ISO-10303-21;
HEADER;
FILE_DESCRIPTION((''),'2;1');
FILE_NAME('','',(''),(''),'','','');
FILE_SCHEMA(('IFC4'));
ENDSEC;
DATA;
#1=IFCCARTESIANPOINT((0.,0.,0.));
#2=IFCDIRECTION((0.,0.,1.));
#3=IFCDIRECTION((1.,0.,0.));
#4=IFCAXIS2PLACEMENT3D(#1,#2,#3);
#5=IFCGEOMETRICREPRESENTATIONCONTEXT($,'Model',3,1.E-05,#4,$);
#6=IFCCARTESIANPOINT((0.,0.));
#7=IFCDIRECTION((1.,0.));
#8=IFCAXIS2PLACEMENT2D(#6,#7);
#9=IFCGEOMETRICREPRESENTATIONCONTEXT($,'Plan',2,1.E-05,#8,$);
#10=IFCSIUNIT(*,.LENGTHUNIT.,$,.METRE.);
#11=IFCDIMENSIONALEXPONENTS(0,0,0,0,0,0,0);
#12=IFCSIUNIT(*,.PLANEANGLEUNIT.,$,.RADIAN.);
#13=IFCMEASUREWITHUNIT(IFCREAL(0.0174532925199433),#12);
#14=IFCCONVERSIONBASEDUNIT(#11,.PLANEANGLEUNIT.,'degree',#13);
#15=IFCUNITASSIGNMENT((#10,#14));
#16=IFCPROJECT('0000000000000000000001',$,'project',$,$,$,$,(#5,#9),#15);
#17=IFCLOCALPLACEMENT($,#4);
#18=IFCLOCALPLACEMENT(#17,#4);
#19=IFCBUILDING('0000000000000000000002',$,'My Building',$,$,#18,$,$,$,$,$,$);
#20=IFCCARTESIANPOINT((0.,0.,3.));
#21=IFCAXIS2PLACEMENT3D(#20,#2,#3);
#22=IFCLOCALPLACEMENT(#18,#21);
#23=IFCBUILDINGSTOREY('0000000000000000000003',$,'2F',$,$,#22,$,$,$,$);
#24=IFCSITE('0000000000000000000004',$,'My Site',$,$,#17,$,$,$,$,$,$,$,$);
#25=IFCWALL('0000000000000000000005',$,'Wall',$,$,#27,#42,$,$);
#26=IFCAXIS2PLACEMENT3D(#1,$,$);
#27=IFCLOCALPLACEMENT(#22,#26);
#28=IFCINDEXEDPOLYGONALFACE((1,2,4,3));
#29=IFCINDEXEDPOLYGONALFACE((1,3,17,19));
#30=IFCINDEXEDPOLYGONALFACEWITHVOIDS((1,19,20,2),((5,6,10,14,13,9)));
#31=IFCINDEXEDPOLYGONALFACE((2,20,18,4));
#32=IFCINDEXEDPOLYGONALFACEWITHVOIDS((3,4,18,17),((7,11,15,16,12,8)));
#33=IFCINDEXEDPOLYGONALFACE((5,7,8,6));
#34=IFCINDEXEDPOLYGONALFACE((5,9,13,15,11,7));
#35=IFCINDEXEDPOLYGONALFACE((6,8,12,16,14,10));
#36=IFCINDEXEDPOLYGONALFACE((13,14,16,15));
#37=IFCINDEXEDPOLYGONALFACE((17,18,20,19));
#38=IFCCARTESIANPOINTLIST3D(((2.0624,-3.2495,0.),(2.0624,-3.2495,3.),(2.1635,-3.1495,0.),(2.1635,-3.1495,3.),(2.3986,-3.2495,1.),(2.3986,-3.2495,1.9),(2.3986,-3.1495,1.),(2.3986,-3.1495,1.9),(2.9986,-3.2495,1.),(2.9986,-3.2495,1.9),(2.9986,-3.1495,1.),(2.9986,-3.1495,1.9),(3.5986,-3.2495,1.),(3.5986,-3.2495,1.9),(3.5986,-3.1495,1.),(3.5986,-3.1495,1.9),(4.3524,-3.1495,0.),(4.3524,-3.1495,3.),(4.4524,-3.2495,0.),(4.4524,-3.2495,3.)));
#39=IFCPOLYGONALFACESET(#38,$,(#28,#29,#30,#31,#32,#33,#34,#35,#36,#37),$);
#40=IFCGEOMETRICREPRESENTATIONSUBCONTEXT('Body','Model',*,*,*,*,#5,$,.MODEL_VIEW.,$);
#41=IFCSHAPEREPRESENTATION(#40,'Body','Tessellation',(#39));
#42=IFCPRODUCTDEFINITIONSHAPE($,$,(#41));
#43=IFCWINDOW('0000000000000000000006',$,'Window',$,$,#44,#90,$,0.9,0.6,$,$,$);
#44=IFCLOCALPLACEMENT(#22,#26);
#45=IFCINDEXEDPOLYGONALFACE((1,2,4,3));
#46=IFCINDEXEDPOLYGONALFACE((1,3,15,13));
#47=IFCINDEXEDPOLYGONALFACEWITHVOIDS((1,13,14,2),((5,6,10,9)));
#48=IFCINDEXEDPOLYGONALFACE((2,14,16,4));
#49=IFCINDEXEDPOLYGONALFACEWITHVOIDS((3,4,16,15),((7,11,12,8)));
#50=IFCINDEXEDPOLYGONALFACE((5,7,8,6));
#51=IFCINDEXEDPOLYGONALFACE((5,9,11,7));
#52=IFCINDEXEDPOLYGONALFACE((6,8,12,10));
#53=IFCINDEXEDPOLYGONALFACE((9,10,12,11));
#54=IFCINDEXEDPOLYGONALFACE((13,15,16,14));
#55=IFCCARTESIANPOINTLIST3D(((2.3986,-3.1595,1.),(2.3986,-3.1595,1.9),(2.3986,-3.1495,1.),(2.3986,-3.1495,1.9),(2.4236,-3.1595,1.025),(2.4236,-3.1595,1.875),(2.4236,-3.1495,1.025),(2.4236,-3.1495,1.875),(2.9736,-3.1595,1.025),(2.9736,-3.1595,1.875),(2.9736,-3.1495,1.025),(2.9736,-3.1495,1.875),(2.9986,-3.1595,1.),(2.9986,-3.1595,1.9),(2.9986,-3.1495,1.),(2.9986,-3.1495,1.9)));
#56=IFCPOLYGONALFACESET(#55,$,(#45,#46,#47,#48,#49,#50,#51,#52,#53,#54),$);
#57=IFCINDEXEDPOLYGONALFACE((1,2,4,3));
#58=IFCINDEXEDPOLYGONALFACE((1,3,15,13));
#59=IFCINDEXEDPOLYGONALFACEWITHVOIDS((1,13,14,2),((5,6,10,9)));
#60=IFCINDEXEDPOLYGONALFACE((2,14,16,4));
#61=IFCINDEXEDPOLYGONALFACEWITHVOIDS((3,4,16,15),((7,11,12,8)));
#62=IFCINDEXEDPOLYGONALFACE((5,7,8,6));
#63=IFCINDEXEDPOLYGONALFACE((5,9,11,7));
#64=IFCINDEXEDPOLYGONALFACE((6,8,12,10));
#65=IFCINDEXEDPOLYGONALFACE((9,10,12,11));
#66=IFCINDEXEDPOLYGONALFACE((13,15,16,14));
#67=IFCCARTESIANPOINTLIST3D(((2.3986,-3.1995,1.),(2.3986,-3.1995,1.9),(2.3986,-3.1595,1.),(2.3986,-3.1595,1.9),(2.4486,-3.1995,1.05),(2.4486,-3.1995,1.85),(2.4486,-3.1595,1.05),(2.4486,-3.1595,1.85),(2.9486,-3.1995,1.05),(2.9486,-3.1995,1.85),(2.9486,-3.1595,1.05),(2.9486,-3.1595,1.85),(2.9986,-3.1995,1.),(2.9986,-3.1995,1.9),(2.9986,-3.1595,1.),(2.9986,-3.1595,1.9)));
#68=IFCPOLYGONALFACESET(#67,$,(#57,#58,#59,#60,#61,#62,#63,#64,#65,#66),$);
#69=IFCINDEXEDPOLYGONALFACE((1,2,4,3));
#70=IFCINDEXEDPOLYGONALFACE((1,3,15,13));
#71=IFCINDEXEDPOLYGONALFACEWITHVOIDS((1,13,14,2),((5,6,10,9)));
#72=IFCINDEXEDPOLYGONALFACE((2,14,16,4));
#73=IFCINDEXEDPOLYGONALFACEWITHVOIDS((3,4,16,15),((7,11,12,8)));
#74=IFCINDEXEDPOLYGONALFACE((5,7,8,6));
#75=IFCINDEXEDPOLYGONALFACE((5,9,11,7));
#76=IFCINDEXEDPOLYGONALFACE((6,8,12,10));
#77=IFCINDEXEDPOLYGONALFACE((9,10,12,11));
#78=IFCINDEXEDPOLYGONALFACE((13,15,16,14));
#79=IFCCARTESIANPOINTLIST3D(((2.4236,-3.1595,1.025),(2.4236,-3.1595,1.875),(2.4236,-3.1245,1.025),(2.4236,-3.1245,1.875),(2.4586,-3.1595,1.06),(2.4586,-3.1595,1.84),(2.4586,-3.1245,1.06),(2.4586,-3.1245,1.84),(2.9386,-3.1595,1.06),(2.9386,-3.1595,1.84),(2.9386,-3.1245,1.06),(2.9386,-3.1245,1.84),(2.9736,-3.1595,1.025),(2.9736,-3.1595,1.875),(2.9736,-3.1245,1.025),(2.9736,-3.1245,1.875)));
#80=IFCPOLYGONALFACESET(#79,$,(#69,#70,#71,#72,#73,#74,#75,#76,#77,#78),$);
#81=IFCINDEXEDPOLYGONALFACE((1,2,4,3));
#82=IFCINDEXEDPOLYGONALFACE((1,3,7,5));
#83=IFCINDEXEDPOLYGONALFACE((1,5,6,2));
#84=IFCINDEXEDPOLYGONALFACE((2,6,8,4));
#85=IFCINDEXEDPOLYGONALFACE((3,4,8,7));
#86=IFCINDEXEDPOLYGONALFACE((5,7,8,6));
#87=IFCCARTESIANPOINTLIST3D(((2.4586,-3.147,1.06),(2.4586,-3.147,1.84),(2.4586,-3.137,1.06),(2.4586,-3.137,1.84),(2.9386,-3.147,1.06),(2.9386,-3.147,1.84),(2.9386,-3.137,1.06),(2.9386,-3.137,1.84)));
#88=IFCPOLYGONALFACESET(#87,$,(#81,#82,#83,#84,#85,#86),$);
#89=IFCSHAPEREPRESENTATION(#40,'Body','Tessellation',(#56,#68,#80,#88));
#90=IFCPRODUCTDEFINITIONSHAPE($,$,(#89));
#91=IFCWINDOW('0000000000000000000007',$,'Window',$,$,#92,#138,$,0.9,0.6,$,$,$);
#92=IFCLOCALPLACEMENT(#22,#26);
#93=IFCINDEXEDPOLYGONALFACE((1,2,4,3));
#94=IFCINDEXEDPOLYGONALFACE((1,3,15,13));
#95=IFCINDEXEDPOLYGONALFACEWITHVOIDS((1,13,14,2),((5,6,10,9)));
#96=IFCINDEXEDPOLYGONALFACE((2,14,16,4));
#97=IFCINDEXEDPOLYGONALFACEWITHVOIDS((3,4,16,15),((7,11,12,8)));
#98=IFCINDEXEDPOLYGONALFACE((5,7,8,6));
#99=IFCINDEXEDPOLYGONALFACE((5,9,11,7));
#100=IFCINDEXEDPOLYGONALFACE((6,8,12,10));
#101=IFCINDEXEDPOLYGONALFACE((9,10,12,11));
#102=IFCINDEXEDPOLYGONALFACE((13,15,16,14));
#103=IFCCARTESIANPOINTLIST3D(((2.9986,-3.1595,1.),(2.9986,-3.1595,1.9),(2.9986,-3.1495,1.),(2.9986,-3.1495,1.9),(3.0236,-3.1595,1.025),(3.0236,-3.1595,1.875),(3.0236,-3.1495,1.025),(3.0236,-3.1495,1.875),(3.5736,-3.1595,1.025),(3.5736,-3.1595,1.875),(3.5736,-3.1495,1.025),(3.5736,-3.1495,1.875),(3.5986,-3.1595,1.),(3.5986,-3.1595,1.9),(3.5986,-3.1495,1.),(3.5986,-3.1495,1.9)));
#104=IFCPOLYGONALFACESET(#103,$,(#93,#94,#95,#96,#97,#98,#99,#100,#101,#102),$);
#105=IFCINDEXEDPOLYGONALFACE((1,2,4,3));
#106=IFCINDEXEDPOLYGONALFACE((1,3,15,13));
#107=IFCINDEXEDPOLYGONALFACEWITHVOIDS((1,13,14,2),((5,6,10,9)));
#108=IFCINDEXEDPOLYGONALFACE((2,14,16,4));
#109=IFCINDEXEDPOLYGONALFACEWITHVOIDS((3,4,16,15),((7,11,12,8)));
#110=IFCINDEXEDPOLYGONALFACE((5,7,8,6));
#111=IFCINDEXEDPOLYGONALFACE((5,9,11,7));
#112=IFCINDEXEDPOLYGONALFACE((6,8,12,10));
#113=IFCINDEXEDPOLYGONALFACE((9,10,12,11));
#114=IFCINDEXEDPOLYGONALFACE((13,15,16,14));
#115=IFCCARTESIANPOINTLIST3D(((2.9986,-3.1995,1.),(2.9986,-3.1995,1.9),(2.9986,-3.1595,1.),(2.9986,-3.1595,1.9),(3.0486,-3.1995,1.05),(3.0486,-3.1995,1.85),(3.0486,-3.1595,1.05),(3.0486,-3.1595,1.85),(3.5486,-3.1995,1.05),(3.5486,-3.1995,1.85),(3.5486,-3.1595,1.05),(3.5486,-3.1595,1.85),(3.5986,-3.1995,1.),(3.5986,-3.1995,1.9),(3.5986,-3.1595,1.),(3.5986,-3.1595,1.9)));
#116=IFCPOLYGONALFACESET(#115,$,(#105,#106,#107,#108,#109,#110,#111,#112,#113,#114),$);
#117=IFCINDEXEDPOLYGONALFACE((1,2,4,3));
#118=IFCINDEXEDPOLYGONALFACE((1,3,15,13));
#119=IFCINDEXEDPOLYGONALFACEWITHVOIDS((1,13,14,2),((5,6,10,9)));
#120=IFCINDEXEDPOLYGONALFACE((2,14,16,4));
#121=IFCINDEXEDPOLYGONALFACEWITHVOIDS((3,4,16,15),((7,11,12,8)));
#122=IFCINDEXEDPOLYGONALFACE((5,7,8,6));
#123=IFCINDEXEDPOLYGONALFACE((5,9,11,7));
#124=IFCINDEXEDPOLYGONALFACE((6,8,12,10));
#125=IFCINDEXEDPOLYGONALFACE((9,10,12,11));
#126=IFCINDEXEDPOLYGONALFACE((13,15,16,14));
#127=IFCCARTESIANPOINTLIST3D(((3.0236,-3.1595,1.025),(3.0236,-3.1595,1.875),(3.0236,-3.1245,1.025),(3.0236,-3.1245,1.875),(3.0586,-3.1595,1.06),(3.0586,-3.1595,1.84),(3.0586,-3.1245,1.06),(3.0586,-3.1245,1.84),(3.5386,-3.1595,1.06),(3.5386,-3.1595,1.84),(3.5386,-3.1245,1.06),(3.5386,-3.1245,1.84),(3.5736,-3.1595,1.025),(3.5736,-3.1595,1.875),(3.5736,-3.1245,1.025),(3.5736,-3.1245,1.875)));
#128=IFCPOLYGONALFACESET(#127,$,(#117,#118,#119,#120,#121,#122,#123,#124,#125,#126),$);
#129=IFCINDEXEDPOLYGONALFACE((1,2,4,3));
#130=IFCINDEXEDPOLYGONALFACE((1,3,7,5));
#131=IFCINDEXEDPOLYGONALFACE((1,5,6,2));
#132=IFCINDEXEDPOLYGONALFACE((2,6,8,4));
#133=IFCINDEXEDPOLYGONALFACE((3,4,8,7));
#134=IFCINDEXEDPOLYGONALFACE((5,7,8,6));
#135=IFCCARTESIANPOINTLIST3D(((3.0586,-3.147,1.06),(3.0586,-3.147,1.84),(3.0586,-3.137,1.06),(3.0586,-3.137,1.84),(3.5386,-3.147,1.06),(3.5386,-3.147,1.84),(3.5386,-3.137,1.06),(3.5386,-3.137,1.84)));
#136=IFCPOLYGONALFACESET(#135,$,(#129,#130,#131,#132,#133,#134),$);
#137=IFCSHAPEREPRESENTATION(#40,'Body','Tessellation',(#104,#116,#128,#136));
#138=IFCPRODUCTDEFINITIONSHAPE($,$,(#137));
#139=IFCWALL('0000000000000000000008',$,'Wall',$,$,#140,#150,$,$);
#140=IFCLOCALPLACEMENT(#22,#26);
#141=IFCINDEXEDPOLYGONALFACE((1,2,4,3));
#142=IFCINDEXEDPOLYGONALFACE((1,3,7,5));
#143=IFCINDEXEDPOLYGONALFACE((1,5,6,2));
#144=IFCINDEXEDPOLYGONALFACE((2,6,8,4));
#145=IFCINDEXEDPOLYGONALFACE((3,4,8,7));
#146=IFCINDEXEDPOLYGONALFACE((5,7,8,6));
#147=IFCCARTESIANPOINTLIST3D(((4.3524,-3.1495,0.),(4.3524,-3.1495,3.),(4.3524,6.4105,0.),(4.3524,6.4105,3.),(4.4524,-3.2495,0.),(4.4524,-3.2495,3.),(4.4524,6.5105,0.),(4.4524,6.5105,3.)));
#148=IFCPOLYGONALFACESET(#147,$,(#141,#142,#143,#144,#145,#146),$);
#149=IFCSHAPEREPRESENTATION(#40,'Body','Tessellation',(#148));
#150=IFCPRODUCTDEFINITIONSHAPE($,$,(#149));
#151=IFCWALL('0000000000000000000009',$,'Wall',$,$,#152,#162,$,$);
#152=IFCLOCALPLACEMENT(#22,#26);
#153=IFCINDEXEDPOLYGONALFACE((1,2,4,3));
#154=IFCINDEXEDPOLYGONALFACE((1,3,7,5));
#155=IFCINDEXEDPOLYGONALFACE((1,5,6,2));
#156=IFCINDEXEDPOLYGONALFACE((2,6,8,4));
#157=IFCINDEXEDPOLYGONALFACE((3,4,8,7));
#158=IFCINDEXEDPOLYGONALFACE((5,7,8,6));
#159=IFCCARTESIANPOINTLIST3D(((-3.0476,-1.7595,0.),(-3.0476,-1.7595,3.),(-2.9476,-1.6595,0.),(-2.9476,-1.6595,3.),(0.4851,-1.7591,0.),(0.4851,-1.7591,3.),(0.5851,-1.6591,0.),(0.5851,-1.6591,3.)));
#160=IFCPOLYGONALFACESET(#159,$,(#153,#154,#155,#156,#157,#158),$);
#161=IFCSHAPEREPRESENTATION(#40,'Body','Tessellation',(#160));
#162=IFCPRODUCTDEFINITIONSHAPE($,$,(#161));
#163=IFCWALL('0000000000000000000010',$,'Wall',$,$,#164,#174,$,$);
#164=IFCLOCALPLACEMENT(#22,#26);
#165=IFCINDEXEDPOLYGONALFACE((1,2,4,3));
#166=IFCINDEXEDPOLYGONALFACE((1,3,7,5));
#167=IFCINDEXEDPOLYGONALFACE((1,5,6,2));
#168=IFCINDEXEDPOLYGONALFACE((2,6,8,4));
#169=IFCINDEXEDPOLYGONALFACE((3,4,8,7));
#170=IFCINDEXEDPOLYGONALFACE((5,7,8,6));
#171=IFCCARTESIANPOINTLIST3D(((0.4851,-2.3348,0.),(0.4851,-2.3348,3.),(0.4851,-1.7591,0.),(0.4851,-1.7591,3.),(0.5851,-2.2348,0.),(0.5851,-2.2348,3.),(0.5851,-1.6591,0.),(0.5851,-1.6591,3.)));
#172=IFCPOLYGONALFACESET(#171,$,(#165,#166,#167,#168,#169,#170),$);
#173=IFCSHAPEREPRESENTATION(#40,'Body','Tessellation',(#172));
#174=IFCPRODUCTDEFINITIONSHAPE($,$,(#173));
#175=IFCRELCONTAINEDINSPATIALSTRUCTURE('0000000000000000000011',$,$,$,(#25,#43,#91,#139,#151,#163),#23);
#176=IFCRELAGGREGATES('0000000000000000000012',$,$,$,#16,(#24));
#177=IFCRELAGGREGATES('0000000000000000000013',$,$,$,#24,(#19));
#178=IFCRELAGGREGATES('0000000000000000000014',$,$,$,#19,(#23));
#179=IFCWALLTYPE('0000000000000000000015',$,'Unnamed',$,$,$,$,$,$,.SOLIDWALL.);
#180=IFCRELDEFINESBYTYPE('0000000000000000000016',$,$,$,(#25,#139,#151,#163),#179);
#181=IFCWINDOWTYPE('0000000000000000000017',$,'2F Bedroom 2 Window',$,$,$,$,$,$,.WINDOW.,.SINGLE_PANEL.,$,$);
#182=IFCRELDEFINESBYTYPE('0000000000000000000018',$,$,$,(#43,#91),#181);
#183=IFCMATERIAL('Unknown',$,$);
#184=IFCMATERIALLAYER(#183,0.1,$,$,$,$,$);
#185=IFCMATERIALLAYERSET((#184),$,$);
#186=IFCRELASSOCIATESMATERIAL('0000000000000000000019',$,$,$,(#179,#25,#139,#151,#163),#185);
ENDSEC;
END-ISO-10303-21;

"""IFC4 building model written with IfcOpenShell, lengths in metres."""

from ifc_helpers import new_model, entity, si_unit, converted_unit, frame, origin_with_axes, origin_2d_with_axis, place, context, subcontext, project, spatial, line, indexed_curve, outline, extrude, shape, source, transform, mapped, material, layer, layer_set, layer_usage, type_object, type_shapes, element, fill, save


model = new_model("IFC4")

# Units and contexts
model_context = context("Model", 3, precision=1e-05, world=origin_with_axes())
plan_context = context("Plan", 2, precision=1e-05, world=origin_2d_with_axis())
body_context_1 = subcontext(model_context, "Body", "Model", "MODEL_VIEW")
body_context_2 = subcontext(plan_context, "Body", "Plan", "PLAN_VIEW")
ifc_project = project(units=[si_unit("LENGTHUNIT", "METRE"), converted_unit("PLANEANGLEUNIT", "degree", entity("IfcReal", 0.0174532925199433), si_unit("PLANEANGLEUNIT", "RADIAN"), dimensions=[0, 0, 0, 0, 0, 0, 0])], contexts=[model_context, plan_context])

# Site, building, storey
site_placement = place(None, origin_with_axes())
site = spatial("IfcSite", under=ifc_project, at=site_placement, Name="My Site")
building_placement = place(site_placement, origin_with_axes())
building = spatial("IfcBuilding", under=site, at=building_placement, Name="My Building")
storey_placement = place(building_placement, frame((0.0, 0.0, 3.0), z_axis=(0.0, 0.0, 1.0), x_axis=(1.0, 0.0, 0.0)))
storey = spatial("IfcBuildingStorey", under=building, at=storey_placement, Name="2F")

# Shared definitions
ifc_material = material(Name="Unknown")

# Wall, openings, windows
ifc_layer_1 = layer(ifc_material, 0.1)
ifc_layer_set_1 = layer_set([ifc_layer_1])
ifc_layer_usage_1 = layer_usage(ifc_layer_set_1, "AXIS2", "POSITIVE", 0.0)
wall_type = type_object("IfcWallType", Name="Unnamed", PredefinedType="SOLIDWALL", material=ifc_layer_set_1)
wall_1_placement = place(storey_placement, frame((2.0624, -3.2495, 0.0), z_axis=(0.0, 0.0, 1.0), x_axis=(1.0, 0.0, 0.0)))
wall_1 = element("IfcWall", 1, at=wall_1_placement, inside=storey, type_object=wall_type, material=ifc_layer_usage_1, Name="Wall", context=body_context_1, shape_type="SweptSolid", body=[
    extrude(outline(indexed_curve([(0.0, 0.0), (0.1011, 0.1), (2.29, 0.1), (2.39, 0.0)], segments=[line(1, 2, 3, 4, 1)])), origin_with_axes(), (0.0, 0.0, 1.0), 3.0),
])
shared_shape_1 = source(origin_with_axes(), body_context_1, "Body", "SweptSolid", [
    extrude(outline(indexed_curve([(0.0, 0.0), (0.6, 0.0), (0.6, 0.9), (0.0, 0.9)], segments=[line(1, 2, 3, 4, 1)])), frame((0.0, -0.6, 0.0), z_axis=(0.0, -1.0, 0.0), x_axis=(1.0, 0.0, 0.0)), (0.0, 0.0, -1.0), 1.2),
])
opening_1_placement = place(wall_1_placement, frame((0.3362, 0.0, 1.0), z_axis=(0.0, 0.0, 1.0), x_axis=(1.0, 0.0, 0.0)))
opening_1 = element("IfcOpeningElement", 2, at=opening_1_placement, cuts=wall_1, PredefinedType="OPENING", context=body_context_1, shape_type="MappedRepresentation", body=[
    mapped(shared_shape_1, transform((0.0, 0.0, 0.0), x_axis=(1.0, 0.0, 0.0), y_axis=(0.0, 1.0, 0.0), z_axis=(0.0, 0.0, 1.0), scale=1.0)),
])
opening_2_placement = place(wall_1_placement, frame((0.9362, 0.0, 1.0), z_axis=(0.0, 0.0, 1.0), x_axis=(1.0, 0.0, 0.0)))
opening_2 = element("IfcOpeningElement", 3, at=opening_2_placement, cuts=wall_1, PredefinedType="OPENING", context=body_context_1, shape_type="MappedRepresentation", body=[
    mapped(shared_shape_1, transform((0.0, 0.0, 0.0), x_axis=(1.0, 0.0, 0.0), y_axis=(0.0, 1.0, 0.0), z_axis=(0.0, 0.0, 1.0), scale=1.0)),
])
window_type = type_object("IfcWindowType", Name="2F Bedroom 2 Window", PartitioningType="SINGLE_PANEL", PredefinedType="WINDOW")
shared_shape_2 = source(origin_with_axes(), body_context_1, "Body", "SweptSolid", [
    extrude(outline(indexed_curve([(0.0, 0.0), (0.6, 0.0), (0.6, 0.9), (0.0, 0.9)], segments=[line(1, 2, 3, 4, 1)]), holes=[indexed_curve([(0.025, 0.025), (0.575, 0.025), (0.575, 0.875), (0.025, 0.875)], segments=[line(1, 2, 3, 4, 1)])]), frame((0.0, 0.09, 0.0), z_axis=(0.0, -1.0, 0.0), x_axis=(1.0, 0.0, 0.0)), (0.0, 0.0, -1.0), 0.01),
    extrude(outline(indexed_curve([(0.0, 0.0), (0.6, 0.0), (0.6, 0.9), (0.0, 0.9)], segments=[line(1, 2, 3, 4, 1)]), holes=[indexed_curve([(0.05, 0.05), (0.55, 0.05), (0.55, 0.85), (0.05, 0.85)], segments=[line(1, 2, 3, 4, 1)])]), frame((0.0, 0.05, 0.0), z_axis=(0.0, -1.0, 0.0), x_axis=(1.0, 0.0, 0.0)), (0.0, 0.0, -1.0), 0.04),
    extrude(outline(indexed_curve([(0.0, 0.0), (0.55, 0.0), (0.55, 0.85), (0.0, 0.85)], segments=[line(1, 2, 3, 4, 1)]), holes=[indexed_curve([(0.035, 0.035), (0.515, 0.035), (0.515, 0.815), (0.035, 0.815)], segments=[line(1, 2, 3, 4, 1)])]), frame((0.025, 0.09, 0.025), z_axis=(0.0, -1.0, 0.0), x_axis=(1.0, 0.0, 0.0)), (0.0, 0.0, -1.0), 0.035),
    extrude(outline(indexed_curve([(0.035, 0.035), (0.515, 0.035), (0.515, 0.815), (0.035, 0.815)], segments=[line(1, 2, 3, 4, 1)])), frame((0.025, 0.1025, 0.025), z_axis=(0.0, -1.0, 0.0), x_axis=(1.0, 0.0, 0.0)), (0.0, 0.0, -1.0), 0.01),
])
shared_shape_3 = source(origin_with_axes(), body_context_2, "Body", "Curve2D", [
    entity("IfcIndexedPolyCurve", entity("IfcCartesianPointList2D", [[0.05, 0.05], [0.55, 0.05]])),
    entity("IfcIndexedPolyCurve", entity("IfcCartesianPointList2D", [[0.0, 0.1], [0.025, 0.1], [0.025, 0.09], [0.05, 0.09], [0.05, 0.05], [0.0, 0.05]]), [entity("IfcLineIndex", [1, 2, 3, 4, 5, 6, 1])]),
    entity("IfcIndexedPolyCurve", entity("IfcCartesianPointList2D", [[0.6, 0.1], [0.575, 0.1], [0.575, 0.09], [0.55, 0.09], [0.55, 0.05], [0.6, 0.05]]), [entity("IfcLineIndex", [1, 2, 3, 4, 5, 6, 1])]),
    entity("IfcIndexedPolyCurve", entity("IfcCartesianPointList2D", [[0.025, 0.09], [0.06, 0.09], [0.06, 0.125], [0.025, 0.125]]), [entity("IfcLineIndex", [1, 2, 3, 4, 1])]),
    entity("IfcIndexedPolyCurve", entity("IfcCartesianPointList2D", [[0.575, 0.09], [0.54, 0.09], [0.54, 0.125], [0.575, 0.125]]), [entity("IfcLineIndex", [1, 2, 3, 4, 1])]),
    entity("IfcIndexedPolyCurve", entity("IfcCartesianPointList2D", [[0.06, 0.09], [0.54, 0.09]])),
    entity("IfcIndexedPolyCurve", entity("IfcCartesianPointList2D", [[0.06, 0.125], [0.54, 0.125]])),
    entity("IfcIndexedPolyCurve", entity("IfcCartesianPointList2D", [[0.06, 0.1075], [0.54, 0.1075]])),
])
type_shapes(window_type, [shared_shape_2, shared_shape_3])
window_1_placement = place(opening_1_placement, origin_with_axes())
window_1 = element("IfcWindow", 4, at=window_1_placement, inside=storey, type_object=window_type, Name="Window", OverallHeight=0.9, OverallWidth=0.6, shapes=[
    shape(body_context_1, "Body", "MappedRepresentation", [mapped(shared_shape_2, transform((0.0, 0.0, 0.0), x_axis=(1.0, 0.0, 0.0), y_axis=(0.0, 1.0, 0.0), z_axis=(0.0, 0.0, 1.0), scale=1.0))]),
    shape(body_context_2, "Body", "MappedRepresentation", [mapped(shared_shape_3, transform((0.0, 0.0, 0.0), x_axis=(1.0, 0.0, 0.0), y_axis=(0.0, 1.0, 0.0), z_axis=(0.0, 0.0, 1.0), scale=1.0))]),
])
fill(opening_1, window_1)
window_2_placement = place(opening_2_placement, origin_with_axes())
window_2 = element("IfcWindow", 5, at=window_2_placement, inside=storey, type_object=window_type, Name="Window", OverallHeight=0.9, OverallWidth=0.6, shapes=[
    shape(body_context_1, "Body", "MappedRepresentation", [mapped(shared_shape_2, transform((0.0, 0.0, 0.0), x_axis=(1.0, 0.0, 0.0), y_axis=(0.0, 1.0, 0.0), z_axis=(0.0, 0.0, 1.0), scale=1.0))]),
    shape(body_context_2, "Body", "MappedRepresentation", [mapped(shared_shape_3, transform((0.0, 0.0, 0.0), x_axis=(1.0, 0.0, 0.0), y_axis=(0.0, 1.0, 0.0), z_axis=(0.0, 0.0, 1.0), scale=1.0))]),
])
fill(opening_2, window_2)

# Walls
ifc_layer_usage_2 = layer_usage(ifc_layer_set_1, "AXIS2", "POSITIVE", 0.0)
wall_2_placement = place(storey_placement, frame((4.4524, -3.2495, 0.0), z_axis=(0.0, 0.0, 1.0), x_axis=(0.0, 1.0, 0.0)))
element("IfcWall", 6, at=wall_2_placement, inside=storey, type_object=wall_type, material=ifc_layer_usage_2, Name="Wall", context=body_context_1, shape_type="SweptSolid", body=[
    extrude(outline(indexed_curve([(0.0, 0.0), (0.1, 0.1), (9.66, 0.1), (9.76, 0.0)], segments=[line(1, 2, 3, 4, 1)])), origin_with_axes(), (0.0, 0.0, 1.0), 3.0),
])
ifc_layer_usage_3 = layer_usage(ifc_layer_set_1, "AXIS2", "POSITIVE", 0.0)
wall_3_placement = place(storey_placement, frame((-3.0476, -1.7595, 0.0), z_axis=(0.0, 0.0, 1.0), x_axis=(1.0, 0.000125, 0.0)))
element("IfcWall", 7, at=wall_3_placement, inside=storey, type_object=wall_type, material=ifc_layer_usage_3, Name="Wall", context=body_context_1, shape_type="SweptSolid", body=[
    extrude(outline(indexed_curve([(0.0, 0.0), (0.1, 0.1), (3.6327, 0.1), (3.5327, 0.0)], segments=[line(1, 2, 3, 4, 1)])), origin_with_axes(), (0.0, 0.0, 1.0), 3.0),
])
ifc_layer_usage_4 = layer_usage(ifc_layer_set_1, "AXIS2", "POSITIVE", 0.0)
wall_4_placement = place(storey_placement, frame((0.4851, -1.7591, 0.0), z_axis=(0.0, 0.0, 1.0), x_axis=(0.0, -1.0, 0.0)))
element("IfcWall", 8, at=wall_4_placement, inside=storey, type_object=wall_type, material=ifc_layer_usage_4, Name="Wall", context=body_context_1, shape_type="SweptSolid", body=[
    extrude(outline(indexed_curve([(0.0, 0.0), (-0.1, 0.1), (0.4757, 0.1), (0.5757, 0.0)], segments=[line(1, 2, 3, 4, 1)])), origin_with_axes(), (0.0, 0.0, 1.0), 3.0),
])

save(model, "model.ifc")
